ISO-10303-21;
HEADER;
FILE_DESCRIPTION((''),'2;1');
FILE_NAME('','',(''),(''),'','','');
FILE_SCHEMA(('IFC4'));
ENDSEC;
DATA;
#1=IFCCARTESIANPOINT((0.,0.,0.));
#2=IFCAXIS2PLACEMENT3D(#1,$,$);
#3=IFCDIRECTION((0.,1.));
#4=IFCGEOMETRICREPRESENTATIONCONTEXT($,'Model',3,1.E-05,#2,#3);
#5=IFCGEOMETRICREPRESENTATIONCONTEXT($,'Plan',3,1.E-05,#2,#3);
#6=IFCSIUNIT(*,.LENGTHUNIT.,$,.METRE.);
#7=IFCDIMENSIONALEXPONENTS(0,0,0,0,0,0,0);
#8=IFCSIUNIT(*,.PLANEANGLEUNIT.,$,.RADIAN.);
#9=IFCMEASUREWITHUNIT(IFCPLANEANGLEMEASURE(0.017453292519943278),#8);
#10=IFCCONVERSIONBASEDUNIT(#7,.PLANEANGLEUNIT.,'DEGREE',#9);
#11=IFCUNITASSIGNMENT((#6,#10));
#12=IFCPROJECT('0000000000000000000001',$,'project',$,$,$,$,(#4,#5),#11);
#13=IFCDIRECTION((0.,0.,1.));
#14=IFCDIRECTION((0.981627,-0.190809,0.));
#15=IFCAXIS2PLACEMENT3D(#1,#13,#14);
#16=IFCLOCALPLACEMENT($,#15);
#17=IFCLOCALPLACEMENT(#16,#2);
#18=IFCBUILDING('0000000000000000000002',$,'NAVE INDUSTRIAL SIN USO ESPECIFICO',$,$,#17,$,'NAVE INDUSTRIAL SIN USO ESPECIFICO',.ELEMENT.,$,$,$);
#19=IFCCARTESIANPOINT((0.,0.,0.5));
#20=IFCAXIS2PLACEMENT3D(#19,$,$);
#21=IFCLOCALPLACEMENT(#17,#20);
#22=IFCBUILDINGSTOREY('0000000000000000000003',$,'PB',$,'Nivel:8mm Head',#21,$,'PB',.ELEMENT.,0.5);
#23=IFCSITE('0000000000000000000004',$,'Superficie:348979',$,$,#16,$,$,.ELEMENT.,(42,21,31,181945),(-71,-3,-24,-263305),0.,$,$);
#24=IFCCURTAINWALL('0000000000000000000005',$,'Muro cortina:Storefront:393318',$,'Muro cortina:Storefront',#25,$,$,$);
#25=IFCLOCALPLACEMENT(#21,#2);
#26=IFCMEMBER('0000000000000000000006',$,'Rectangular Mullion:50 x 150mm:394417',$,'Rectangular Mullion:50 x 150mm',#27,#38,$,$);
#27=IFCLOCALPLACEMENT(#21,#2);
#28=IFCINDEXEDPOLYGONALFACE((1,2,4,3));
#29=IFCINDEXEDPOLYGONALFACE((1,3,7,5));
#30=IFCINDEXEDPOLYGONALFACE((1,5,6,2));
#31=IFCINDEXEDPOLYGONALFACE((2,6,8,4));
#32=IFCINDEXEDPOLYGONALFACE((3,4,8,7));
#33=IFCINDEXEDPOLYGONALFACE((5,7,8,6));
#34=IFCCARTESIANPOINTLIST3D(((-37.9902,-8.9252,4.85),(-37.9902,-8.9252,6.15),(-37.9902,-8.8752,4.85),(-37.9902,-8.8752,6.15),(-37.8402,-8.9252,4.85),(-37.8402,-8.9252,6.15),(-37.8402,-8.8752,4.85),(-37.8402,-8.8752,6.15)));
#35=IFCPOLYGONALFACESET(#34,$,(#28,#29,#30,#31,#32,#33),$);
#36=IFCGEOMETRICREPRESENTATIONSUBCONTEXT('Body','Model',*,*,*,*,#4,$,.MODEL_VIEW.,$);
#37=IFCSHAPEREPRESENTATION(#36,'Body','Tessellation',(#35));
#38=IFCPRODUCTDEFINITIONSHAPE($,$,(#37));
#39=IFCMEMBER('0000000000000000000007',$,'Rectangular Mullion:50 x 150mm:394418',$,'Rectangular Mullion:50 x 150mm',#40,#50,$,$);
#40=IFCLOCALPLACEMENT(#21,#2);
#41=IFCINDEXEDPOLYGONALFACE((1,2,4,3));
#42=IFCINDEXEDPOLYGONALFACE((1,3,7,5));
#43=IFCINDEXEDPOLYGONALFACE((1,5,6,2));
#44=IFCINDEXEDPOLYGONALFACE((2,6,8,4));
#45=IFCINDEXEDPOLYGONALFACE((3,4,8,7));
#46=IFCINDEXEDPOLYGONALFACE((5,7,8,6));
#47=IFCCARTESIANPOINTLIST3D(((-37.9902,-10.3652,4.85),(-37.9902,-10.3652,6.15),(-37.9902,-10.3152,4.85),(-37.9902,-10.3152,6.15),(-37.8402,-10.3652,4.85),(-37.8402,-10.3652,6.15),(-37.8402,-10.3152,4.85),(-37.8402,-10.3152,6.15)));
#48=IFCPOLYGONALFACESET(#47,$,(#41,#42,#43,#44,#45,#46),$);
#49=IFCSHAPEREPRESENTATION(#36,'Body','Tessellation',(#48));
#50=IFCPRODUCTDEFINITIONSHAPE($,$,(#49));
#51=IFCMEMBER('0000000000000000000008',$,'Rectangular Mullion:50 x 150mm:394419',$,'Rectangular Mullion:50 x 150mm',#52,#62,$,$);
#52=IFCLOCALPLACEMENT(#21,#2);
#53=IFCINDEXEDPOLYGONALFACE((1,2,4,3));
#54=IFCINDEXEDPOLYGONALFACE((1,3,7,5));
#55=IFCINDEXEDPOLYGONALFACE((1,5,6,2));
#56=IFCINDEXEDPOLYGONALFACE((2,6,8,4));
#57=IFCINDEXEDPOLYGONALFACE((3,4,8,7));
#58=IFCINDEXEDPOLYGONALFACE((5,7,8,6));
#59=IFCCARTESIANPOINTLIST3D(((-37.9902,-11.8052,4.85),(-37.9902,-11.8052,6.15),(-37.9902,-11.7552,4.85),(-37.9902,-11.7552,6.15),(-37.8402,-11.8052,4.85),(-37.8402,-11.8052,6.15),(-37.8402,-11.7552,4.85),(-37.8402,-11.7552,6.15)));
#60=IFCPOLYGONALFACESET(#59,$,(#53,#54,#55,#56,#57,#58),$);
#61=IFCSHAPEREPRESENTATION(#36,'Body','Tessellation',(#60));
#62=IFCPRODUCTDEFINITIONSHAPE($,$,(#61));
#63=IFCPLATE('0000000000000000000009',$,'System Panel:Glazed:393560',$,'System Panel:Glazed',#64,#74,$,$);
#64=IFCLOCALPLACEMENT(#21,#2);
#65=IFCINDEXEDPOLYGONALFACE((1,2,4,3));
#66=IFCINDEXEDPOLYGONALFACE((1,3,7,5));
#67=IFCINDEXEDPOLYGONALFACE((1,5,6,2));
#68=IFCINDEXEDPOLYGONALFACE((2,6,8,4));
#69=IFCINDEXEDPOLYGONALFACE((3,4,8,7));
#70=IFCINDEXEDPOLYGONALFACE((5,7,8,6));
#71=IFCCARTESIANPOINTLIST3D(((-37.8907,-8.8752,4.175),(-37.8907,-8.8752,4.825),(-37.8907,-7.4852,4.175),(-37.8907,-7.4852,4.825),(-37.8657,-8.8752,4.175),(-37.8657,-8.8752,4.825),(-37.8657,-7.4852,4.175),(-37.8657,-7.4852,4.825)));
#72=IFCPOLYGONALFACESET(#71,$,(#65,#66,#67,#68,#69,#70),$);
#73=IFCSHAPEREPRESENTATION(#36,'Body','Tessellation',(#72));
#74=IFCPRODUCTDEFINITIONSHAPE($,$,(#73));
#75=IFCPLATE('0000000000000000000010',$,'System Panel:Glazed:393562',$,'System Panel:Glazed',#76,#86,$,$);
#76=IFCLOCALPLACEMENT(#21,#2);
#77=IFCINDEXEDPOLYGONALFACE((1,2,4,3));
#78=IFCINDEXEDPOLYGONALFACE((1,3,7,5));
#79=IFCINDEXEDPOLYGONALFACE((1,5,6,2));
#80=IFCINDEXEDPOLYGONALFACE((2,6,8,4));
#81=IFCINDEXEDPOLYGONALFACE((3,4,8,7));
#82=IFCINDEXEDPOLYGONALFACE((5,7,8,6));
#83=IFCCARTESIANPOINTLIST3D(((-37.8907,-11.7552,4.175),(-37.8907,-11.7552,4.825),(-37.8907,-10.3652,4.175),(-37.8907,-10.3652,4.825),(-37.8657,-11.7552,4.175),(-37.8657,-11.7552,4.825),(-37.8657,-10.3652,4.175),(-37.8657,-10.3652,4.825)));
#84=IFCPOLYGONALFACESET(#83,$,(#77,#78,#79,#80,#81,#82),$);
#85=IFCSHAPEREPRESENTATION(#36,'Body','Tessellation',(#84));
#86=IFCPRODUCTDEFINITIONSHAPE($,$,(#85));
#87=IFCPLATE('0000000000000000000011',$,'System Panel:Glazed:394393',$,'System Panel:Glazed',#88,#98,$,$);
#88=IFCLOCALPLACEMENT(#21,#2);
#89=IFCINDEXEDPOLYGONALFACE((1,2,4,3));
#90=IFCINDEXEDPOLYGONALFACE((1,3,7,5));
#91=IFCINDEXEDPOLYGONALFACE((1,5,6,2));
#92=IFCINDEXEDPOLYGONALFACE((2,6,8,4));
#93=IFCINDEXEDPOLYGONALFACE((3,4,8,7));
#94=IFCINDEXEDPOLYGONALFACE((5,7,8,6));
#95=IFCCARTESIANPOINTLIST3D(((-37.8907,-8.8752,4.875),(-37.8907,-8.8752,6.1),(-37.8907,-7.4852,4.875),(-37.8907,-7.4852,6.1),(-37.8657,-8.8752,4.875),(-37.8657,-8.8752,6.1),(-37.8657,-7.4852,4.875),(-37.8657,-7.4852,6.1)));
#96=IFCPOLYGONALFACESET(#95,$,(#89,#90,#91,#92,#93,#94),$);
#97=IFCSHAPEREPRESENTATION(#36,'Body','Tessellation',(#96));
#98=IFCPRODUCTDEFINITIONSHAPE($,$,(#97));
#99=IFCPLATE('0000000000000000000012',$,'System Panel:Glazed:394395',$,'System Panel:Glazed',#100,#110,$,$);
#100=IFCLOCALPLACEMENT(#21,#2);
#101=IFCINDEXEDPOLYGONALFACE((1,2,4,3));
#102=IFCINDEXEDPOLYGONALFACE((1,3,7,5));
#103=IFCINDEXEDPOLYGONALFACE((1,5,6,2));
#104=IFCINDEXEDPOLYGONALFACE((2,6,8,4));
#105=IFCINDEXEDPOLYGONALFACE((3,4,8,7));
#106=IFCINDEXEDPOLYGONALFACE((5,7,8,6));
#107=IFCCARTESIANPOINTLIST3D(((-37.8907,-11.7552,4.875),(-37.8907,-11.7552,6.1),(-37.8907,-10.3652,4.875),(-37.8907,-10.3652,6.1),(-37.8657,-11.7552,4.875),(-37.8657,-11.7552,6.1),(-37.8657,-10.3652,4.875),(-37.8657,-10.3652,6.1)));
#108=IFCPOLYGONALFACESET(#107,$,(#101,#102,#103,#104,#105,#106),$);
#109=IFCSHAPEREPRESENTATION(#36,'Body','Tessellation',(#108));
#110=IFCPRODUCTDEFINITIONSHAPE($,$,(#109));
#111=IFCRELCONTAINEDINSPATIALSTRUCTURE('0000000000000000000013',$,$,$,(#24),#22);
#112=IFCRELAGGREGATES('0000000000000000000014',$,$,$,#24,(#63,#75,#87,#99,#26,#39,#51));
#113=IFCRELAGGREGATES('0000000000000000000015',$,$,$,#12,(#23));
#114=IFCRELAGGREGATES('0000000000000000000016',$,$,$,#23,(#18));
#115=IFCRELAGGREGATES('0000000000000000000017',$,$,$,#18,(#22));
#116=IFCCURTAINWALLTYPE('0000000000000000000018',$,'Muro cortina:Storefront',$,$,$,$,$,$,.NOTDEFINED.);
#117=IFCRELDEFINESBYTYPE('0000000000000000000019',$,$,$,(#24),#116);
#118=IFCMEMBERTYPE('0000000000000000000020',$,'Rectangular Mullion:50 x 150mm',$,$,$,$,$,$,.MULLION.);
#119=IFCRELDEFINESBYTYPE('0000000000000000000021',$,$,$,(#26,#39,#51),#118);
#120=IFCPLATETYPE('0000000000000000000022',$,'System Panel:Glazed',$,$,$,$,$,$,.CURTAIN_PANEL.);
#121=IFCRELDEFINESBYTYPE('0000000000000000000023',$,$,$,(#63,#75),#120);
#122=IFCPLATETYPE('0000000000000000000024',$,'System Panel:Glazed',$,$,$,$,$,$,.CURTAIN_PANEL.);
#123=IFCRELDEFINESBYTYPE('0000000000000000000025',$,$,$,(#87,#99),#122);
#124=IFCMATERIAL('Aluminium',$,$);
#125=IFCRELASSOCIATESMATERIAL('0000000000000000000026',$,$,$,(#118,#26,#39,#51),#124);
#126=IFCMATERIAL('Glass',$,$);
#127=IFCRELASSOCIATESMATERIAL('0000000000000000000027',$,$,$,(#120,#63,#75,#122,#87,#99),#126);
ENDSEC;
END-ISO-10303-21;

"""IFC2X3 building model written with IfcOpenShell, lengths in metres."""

from ifc_helpers import new_model, entity, si_unit, converted_unit, direction, frame, origin, origin_2d_with_axis, place, context, subcontext, project, spatial, rectangle, extrude, source, transform, mapped, material, type_object, type_shapes, element, aggregate, save


model = new_model("IFC2X3")

# Units and contexts
model_context = context("Model", 3, precision=1e-05, world=origin(), true_north=direction((0.0, 1.0)))
plan_context = context("Plan", 3, precision=1e-05, world=origin(), true_north=direction((0.0, 1.0)))
body_context = subcontext(model_context, "Body", "Model", "MODEL_VIEW")
ifc_project = project(units=[si_unit("LENGTHUNIT", "METRE"), converted_unit("PLANEANGLEUNIT", "DEGREE", entity("IfcPlaneAngleMeasure", 0.017453292519943278), si_unit("PLANEANGLEUNIT", "RADIAN"), dimensions=[0, 0, 0, 0, 0, 0, 0])], contexts=[model_context, plan_context])

# Site, building, storey
site_placement = place(None, frame((0.0, 0.0, 0.0), z_axis=(0.0, 0.0, 1.0), x_axis=(0.981627, -0.190809, 0.0)))
site = spatial("IfcSite", under=ifc_project, at=site_placement, Name="Superficie:348979", CompositionType="ELEMENT", RefLatitude=(42, 21, 31, 181945), RefLongitude=(-71, -3, -24, -263305), RefElevation=0.0)
building_placement = place(site_placement, origin())
building = spatial("IfcBuilding", under=site, at=building_placement, Name="NAVE INDUSTRIAL SIN USO ESPECIFICO", LongName="NAVE INDUSTRIAL SIN USO ESPECIFICO", CompositionType="ELEMENT")
storey_placement = place(building_placement, frame((0.0, 0.0, 0.5)))
storey = spatial("IfcBuildingStorey", under=building, at=storey_placement, Name="PB", ObjectType="Nivel:8mm Head", LongName="PB", CompositionType="ELEMENT", Elevation=0.5)

# Curtain wall, members, plates
curtain_wall_type = type_object("IfcCurtainWallType", Name="Muro cortina:Storefront", PredefinedType="NOTDEFINED")
curtain_wall_placement = place(storey_placement, frame((0.0, 0.0, -0.5)))
curtain_wall = element("IfcCurtainWall", 1, at=curtain_wall_placement, inside=storey, type_object=curtain_wall_type, Name="Muro cortina:Storefront:393318", ObjectType="Muro cortina:Storefront")
ifc_material_1 = material(Name="Aluminium")
member_type_1 = type_object("IfcMemberType", Name="Rectangular Mullion:50 x 150mm", PredefinedType="MULLION", material=ifc_material_1)
shared_shape_1 = source(origin(), body_context, "Body", "SweptSolid", [
    extrude(rectangle(XDim=0.05, YDim=0.15, at=origin_2d_with_axis()), frame((0.0, 0.0, -1.3), z_axis=(0.0, 0.0, 1.0), x_axis=(-1.0, 0.0, 0.0)), (0.0, 0.0, 1.0), 1.3),
])
type_shapes(member_type_1, [shared_shape_1])
member_1_placement = place(curtain_wall_placement, frame((-37.9152, -8.9002, 5.35), z_axis=(0.0, 0.0, -1.0), x_axis=(0.0, -1.0, 0.0)))
member_1 = element("IfcMember", 2, at=member_1_placement, type_object=member_type_1, material=ifc_material_1, Name="Rectangular Mullion:50 x 150mm:394417", ObjectType="Rectangular Mullion:50 x 150mm", context=body_context, shape_type="MappedRepresentation", body=[
    mapped(shared_shape_1, transform((0.0, 0.0, 0.0), scale=1.0)),
])
member_2_placement = place(curtain_wall_placement, frame((-37.9152, -10.3402, 5.35), z_axis=(0.0, 0.0, -1.0), x_axis=(0.0, -1.0, 0.0)))
member_2 = element("IfcMember", 3, at=member_2_placement, type_object=member_type_1, material=ifc_material_1, Name="Rectangular Mullion:50 x 150mm:394418", ObjectType="Rectangular Mullion:50 x 150mm", context=body_context, shape_type="MappedRepresentation", body=[
    mapped(shared_shape_1, transform((0.0, 0.0, 0.0), scale=1.0)),
])
member_3_placement = place(curtain_wall_placement, frame((-37.9152, -11.7802, 5.35), z_axis=(0.0, 0.0, -1.0), x_axis=(0.0, -1.0, 0.0)))
member_3 = element("IfcMember", 4, at=member_3_placement, type_object=member_type_1, material=ifc_material_1, Name="Rectangular Mullion:50 x 150mm:394419", ObjectType="Rectangular Mullion:50 x 150mm", context=body_context, shape_type="MappedRepresentation", body=[
    mapped(shared_shape_1, transform((0.0, 0.0, 0.0), scale=1.0)),
])
ifc_material_2 = material(Name="Glass")
plate_type_1 = type_object("IfcPlateType", Name="System Panel:Glazed", PredefinedType="CURTAIN_PANEL", material=ifc_material_2)
shared_shape_2 = source(origin(), body_context, "Body", "SweptSolid", [
    extrude(rectangle(XDim=0.025, YDim=1.39, at=origin_2d_with_axis()), frame((0.695, 0.0125, 0.0), z_axis=(0.0, 0.0, 1.0), x_axis=(0.0, 1.0, 0.0)), (0.0, 0.0, 1.0), 0.65),
])
type_shapes(plate_type_1, [shared_shape_2])
plate_1_placement = place(curtain_wall_placement, frame((-37.8907, -7.4852, 4.675), z_axis=(0.0, 0.0, 1.0), x_axis=(0.0, -1.0, 0.0)))
plate_1 = element("IfcPlate", 5, at=plate_1_placement, type_object=plate_type_1, material=ifc_material_2, Name="System Panel:Glazed:393560", ObjectType="System Panel:Glazed", context=body_context, shape_type="MappedRepresentation", body=[
    mapped(shared_shape_2, transform((0.0, 0.0, 0.0), scale=1.0)),
])
plate_2_placement = place(curtain_wall_placement, frame((-37.8907, -10.3652, 4.675), z_axis=(0.0, 0.0, 1.0), x_axis=(0.0, -1.0, 0.0)))
plate_2 = element("IfcPlate", 6, at=plate_2_placement, type_object=plate_type_1, material=ifc_material_2, Name="System Panel:Glazed:393562", ObjectType="System Panel:Glazed", context=body_context, shape_type="MappedRepresentation", body=[
    mapped(shared_shape_2, transform((0.0, 0.0, 0.0), scale=1.0)),
])
plate_type_2 = type_object("IfcPlateType", Name="System Panel:Glazed", PredefinedType="CURTAIN_PANEL", material=ifc_material_2)
shared_shape_3 = source(origin(), body_context, "Body", "SweptSolid", [
    extrude(rectangle(XDim=0.025, YDim=1.39, at=origin_2d_with_axis()), frame((0.695, 0.0125, 0.0), z_axis=(0.0, 0.0, 1.0), x_axis=(0.0, 1.0, 0.0)), (0.0, 0.0, 1.0), 1.225),
])
type_shapes(plate_type_2, [shared_shape_3])
plate_3_placement = place(curtain_wall_placement, frame((-37.8907, -7.4852, 5.375), z_axis=(0.0, 0.0, 1.0), x_axis=(0.0, -1.0, 0.0)))
plate_3 = element("IfcPlate", 7, at=plate_3_placement, type_object=plate_type_2, material=ifc_material_2, Name="System Panel:Glazed:394393", ObjectType="System Panel:Glazed", context=body_context, shape_type="MappedRepresentation", body=[
    mapped(shared_shape_3, transform((0.0, 0.0, 0.0), scale=1.0)),
])
plate_4_placement = place(curtain_wall_placement, frame((-37.8907, -10.3652, 5.375), z_axis=(0.0, 0.0, 1.0), x_axis=(0.0, -1.0, 0.0)))
plate_4 = element("IfcPlate", 8, at=plate_4_placement, type_object=plate_type_2, material=ifc_material_2, Name="System Panel:Glazed:394395", ObjectType="System Panel:Glazed", context=body_context, shape_type="MappedRepresentation", body=[
    mapped(shared_shape_3, transform((0.0, 0.0, 0.0), scale=1.0)),
])
aggregate(curtain_wall, [plate_1, plate_2, plate_3, plate_4, member_1, member_2, member_3])

save(model, "model.ifc")
